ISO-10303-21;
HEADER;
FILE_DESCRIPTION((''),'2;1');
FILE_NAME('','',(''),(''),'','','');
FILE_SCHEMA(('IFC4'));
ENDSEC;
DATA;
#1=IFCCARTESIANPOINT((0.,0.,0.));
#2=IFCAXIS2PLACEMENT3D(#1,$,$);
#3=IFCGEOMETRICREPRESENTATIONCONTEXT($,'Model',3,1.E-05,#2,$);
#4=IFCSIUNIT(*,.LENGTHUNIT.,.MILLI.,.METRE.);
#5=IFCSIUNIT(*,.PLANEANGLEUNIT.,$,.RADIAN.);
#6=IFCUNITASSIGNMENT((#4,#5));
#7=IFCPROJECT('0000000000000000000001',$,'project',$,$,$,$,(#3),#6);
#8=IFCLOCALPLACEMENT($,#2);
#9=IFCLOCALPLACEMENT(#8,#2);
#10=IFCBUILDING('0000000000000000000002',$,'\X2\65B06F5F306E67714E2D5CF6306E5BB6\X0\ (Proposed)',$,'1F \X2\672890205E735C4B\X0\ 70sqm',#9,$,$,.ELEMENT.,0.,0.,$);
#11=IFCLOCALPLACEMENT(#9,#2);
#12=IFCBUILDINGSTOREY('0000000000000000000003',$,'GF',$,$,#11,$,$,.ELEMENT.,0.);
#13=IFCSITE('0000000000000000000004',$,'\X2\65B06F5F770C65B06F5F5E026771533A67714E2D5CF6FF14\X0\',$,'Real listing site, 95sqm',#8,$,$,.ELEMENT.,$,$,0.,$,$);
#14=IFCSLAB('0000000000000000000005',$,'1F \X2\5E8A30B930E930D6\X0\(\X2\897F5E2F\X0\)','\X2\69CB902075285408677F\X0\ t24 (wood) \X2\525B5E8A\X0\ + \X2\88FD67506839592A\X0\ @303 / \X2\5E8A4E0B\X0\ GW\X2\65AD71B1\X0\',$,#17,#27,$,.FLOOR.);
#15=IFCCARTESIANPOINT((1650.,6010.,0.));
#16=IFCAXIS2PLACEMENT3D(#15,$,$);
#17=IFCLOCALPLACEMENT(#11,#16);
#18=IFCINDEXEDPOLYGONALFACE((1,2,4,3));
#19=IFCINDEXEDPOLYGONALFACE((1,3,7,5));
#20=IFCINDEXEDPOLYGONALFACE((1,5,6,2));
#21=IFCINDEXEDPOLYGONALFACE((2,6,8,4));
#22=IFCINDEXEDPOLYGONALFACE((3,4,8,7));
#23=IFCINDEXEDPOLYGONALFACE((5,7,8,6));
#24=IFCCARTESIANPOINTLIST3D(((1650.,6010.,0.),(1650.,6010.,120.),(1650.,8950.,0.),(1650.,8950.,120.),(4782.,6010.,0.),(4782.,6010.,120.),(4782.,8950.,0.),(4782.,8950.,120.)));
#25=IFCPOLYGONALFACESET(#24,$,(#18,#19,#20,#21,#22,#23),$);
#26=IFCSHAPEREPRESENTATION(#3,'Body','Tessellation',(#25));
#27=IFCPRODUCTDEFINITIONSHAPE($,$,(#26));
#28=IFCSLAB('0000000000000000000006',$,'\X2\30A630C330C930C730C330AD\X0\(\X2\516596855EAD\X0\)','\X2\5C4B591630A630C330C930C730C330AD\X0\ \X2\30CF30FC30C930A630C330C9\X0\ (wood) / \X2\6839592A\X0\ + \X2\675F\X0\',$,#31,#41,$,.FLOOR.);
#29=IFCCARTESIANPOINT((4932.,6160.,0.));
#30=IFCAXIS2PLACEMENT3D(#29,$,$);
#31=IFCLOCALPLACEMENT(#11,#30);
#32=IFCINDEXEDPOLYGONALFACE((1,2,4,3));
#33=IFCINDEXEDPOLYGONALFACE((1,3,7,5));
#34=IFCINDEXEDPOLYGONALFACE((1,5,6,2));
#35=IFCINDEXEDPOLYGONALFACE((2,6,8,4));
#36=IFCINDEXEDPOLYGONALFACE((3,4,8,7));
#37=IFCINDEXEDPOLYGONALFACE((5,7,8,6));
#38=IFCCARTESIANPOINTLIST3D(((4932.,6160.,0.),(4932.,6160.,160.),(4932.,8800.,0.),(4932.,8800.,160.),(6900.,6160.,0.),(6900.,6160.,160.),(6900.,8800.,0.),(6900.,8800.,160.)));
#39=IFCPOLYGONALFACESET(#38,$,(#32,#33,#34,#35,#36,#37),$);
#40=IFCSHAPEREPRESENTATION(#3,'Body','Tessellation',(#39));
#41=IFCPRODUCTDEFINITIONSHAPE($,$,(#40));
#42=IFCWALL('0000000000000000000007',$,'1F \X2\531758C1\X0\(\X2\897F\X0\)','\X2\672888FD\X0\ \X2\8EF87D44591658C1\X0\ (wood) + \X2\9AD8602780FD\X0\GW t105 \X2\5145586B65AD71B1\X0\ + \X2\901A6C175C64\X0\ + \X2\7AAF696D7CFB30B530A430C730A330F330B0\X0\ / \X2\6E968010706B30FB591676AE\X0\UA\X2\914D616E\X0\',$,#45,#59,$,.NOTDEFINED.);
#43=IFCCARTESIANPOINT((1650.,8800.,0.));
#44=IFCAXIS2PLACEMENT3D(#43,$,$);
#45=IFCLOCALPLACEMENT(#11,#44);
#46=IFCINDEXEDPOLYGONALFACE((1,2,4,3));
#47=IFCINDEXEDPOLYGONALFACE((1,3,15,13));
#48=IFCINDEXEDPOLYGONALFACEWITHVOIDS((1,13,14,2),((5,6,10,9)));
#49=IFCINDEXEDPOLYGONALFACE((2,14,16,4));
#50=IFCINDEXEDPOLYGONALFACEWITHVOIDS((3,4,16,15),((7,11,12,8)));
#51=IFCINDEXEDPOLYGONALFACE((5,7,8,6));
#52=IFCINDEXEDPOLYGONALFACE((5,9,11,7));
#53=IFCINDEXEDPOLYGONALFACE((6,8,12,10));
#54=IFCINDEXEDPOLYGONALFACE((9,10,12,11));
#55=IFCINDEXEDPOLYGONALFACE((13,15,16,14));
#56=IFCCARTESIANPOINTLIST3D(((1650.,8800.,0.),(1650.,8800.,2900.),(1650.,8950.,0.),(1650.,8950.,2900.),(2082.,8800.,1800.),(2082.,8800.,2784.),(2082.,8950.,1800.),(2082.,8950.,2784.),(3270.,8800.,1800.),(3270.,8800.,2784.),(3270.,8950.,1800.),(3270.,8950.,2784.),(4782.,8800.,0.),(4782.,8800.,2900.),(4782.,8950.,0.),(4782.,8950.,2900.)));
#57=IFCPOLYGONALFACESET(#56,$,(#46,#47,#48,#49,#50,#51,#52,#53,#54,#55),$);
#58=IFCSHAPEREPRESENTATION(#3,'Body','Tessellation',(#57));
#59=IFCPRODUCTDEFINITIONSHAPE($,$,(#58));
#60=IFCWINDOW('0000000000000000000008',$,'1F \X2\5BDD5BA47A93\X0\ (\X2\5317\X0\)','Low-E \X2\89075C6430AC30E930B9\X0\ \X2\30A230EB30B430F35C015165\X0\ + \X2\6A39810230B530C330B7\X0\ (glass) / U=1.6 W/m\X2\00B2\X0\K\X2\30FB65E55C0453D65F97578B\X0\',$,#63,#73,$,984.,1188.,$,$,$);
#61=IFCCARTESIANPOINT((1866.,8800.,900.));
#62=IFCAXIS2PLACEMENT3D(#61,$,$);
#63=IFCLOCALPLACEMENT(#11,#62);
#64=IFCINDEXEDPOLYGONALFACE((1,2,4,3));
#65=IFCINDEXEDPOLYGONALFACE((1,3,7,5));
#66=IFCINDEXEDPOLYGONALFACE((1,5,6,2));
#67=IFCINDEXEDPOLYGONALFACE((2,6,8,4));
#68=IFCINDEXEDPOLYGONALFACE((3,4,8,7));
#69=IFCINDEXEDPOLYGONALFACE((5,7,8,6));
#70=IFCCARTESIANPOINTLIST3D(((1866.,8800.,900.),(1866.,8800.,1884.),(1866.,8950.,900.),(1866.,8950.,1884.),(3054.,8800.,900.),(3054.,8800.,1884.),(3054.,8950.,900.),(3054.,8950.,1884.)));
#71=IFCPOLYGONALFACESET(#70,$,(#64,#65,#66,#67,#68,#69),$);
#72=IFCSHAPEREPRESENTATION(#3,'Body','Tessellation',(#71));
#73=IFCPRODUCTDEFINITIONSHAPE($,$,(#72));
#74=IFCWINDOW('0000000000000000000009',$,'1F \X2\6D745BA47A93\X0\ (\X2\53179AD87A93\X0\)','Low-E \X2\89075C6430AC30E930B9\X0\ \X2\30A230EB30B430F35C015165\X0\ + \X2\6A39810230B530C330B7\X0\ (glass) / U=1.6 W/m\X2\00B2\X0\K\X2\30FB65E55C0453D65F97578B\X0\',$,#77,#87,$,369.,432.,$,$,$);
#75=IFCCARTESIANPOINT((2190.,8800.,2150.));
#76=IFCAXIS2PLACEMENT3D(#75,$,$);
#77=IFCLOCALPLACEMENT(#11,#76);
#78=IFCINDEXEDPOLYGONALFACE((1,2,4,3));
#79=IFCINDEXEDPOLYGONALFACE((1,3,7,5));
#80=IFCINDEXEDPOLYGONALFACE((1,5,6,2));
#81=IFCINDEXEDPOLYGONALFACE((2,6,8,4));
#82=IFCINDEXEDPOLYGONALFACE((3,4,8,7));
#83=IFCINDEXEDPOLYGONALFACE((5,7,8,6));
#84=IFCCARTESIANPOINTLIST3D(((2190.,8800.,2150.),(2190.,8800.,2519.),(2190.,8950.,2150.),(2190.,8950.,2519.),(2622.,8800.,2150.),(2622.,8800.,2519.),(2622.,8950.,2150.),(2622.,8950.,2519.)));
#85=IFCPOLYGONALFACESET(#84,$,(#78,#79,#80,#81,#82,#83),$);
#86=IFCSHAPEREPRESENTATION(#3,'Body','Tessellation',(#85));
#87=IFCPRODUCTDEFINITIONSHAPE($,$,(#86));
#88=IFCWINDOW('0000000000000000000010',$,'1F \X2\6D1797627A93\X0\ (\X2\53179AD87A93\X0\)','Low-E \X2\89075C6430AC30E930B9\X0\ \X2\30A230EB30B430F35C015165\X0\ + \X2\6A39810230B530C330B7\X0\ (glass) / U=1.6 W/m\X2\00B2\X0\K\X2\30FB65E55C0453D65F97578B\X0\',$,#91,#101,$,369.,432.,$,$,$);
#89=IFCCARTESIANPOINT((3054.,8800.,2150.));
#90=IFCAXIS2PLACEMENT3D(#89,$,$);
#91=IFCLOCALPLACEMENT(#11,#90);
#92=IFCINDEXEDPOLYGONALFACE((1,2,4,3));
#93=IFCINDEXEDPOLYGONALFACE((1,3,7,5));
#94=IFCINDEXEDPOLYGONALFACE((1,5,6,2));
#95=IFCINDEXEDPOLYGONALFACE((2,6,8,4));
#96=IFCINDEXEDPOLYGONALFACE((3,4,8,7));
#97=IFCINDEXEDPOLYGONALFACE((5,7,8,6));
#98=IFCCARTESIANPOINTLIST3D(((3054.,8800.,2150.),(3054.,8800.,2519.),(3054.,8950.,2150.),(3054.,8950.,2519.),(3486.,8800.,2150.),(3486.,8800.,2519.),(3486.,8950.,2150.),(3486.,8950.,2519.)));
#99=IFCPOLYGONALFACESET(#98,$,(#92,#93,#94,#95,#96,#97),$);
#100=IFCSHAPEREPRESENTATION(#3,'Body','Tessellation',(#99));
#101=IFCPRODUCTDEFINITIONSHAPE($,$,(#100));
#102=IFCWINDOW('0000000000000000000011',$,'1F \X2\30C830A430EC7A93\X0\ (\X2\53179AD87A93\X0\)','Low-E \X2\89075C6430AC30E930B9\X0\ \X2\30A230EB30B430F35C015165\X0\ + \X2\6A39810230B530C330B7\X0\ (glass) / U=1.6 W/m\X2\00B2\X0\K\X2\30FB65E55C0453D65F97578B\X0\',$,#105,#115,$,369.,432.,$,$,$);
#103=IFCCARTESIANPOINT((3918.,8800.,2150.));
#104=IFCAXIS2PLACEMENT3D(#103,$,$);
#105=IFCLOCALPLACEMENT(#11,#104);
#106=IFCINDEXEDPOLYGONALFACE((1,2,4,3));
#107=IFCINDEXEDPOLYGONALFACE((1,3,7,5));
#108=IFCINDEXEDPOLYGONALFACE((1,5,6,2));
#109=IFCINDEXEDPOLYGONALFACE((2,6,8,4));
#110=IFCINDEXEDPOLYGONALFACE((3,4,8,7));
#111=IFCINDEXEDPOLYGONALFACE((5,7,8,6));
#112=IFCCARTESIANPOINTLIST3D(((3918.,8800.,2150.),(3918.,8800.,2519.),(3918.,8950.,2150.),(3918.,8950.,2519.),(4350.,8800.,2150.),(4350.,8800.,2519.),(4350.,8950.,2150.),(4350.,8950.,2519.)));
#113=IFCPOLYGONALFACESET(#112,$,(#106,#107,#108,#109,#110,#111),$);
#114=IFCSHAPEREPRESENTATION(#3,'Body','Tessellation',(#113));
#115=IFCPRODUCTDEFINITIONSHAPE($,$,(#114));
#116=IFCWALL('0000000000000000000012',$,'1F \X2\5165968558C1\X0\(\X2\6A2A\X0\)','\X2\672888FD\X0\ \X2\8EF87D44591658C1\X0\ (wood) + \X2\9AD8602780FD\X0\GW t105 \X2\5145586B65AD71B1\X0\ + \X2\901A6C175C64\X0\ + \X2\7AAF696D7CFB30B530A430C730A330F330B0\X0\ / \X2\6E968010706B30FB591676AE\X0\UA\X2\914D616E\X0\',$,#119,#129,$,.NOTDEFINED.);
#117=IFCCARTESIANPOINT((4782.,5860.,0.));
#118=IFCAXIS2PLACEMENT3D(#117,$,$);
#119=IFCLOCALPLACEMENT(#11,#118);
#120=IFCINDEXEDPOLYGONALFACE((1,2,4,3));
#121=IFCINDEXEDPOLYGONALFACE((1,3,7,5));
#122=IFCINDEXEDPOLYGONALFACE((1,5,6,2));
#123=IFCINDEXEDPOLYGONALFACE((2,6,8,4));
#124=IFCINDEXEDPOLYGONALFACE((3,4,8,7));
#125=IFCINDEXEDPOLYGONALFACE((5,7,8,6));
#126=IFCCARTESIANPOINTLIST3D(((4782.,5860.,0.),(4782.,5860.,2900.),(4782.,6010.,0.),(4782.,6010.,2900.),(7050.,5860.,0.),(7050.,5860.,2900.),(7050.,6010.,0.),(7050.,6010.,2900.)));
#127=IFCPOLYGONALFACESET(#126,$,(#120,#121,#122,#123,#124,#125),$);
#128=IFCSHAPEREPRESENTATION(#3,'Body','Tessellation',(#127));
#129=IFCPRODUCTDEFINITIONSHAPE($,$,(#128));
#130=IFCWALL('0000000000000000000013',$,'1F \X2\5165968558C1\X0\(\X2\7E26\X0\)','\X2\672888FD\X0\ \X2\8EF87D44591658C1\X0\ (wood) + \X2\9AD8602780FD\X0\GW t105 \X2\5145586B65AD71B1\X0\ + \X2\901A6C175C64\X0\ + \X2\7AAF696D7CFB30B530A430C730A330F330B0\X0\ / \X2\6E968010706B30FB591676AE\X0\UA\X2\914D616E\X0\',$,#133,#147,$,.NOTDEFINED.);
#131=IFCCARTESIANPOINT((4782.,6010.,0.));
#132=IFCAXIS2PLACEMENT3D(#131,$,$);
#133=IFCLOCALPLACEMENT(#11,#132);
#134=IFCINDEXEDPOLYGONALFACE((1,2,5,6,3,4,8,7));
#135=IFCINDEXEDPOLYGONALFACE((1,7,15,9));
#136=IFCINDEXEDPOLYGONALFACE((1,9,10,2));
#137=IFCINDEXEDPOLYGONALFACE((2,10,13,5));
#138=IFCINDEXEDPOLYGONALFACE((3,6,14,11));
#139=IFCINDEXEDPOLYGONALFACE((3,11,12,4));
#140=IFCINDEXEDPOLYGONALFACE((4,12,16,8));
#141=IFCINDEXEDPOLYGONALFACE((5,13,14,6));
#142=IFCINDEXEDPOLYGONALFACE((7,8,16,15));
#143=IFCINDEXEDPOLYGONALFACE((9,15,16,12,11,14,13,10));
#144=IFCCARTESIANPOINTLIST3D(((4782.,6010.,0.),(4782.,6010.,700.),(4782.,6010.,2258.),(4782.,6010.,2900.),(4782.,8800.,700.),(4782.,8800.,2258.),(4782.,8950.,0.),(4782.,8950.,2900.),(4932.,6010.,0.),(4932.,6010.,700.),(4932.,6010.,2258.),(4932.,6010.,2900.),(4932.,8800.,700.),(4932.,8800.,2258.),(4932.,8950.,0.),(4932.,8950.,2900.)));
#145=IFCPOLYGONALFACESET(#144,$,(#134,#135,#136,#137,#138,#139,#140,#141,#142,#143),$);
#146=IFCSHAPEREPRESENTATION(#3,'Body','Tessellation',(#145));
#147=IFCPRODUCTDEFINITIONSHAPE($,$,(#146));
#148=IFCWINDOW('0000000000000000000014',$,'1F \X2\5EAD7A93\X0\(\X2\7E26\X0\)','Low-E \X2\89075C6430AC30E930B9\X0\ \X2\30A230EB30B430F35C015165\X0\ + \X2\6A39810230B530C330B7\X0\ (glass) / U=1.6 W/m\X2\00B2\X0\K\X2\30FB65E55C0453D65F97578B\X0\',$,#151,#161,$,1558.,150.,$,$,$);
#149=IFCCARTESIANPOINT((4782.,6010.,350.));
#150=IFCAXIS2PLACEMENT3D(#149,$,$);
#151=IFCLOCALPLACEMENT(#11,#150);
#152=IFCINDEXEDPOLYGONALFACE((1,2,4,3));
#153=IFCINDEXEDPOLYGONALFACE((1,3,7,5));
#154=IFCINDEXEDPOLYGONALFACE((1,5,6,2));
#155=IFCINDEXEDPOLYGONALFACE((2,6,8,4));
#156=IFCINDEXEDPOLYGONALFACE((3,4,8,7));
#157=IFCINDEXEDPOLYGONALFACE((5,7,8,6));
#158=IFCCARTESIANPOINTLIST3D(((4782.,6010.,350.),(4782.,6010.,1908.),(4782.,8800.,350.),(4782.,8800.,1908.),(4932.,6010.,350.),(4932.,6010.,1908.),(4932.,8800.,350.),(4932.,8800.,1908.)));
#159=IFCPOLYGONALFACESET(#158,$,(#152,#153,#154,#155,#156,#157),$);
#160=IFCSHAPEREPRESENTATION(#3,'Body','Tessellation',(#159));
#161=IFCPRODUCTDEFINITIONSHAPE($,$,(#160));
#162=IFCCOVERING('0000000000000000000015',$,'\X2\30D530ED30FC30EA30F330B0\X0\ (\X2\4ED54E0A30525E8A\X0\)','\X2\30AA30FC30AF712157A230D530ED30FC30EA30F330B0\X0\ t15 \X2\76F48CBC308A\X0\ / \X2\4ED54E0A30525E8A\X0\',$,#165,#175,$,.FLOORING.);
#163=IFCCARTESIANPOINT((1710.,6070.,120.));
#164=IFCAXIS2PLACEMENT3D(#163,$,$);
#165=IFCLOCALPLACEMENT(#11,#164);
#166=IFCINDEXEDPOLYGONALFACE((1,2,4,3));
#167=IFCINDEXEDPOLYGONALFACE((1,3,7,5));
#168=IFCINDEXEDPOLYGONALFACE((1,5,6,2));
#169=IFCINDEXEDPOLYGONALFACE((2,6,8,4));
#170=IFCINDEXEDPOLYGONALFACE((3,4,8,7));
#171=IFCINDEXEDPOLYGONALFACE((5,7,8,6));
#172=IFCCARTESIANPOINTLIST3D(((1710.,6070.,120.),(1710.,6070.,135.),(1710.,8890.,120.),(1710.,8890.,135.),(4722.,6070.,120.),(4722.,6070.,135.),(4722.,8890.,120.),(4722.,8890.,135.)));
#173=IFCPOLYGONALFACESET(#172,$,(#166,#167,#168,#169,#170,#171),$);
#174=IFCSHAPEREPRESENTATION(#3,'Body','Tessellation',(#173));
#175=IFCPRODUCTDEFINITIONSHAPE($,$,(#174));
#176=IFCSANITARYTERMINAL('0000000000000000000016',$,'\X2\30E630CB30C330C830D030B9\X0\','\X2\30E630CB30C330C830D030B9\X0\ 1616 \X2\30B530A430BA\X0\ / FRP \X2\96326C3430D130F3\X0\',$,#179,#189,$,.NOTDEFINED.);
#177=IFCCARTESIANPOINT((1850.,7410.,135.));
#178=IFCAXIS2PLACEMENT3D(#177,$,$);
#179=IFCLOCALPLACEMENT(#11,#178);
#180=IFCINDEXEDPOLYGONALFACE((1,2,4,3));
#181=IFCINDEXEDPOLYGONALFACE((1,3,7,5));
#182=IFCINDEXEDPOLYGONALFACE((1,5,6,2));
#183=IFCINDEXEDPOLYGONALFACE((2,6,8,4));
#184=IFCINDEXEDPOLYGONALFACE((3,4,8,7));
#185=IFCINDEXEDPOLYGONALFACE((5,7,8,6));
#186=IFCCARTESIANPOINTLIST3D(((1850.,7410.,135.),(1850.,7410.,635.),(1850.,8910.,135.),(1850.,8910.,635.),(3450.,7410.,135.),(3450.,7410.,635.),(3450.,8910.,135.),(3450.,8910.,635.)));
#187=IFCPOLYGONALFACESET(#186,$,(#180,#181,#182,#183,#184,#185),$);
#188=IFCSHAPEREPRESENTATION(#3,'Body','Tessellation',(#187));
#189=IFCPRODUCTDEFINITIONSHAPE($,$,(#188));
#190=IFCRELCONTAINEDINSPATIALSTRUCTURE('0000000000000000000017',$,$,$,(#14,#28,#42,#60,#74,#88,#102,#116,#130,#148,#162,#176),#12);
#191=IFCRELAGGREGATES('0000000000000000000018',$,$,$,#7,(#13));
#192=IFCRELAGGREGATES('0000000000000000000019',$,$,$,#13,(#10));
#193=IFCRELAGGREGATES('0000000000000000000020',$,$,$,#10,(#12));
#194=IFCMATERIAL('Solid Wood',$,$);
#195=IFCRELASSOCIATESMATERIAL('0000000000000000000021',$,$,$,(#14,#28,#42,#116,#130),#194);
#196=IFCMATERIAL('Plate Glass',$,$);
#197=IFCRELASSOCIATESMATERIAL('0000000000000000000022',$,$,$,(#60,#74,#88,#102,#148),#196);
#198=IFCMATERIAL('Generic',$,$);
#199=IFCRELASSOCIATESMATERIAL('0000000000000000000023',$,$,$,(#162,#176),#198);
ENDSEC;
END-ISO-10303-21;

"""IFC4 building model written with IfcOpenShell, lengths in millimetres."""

from ifc_helpers import new_model, si_unit, frame, frame_2d, origin, place, context, project, spatial, rectangle, extrude, material, element, fill, save


model = new_model("IFC4")

# Units and contexts
model_context = context("Model", 3, precision=1e-05, world=origin())
ifc_project = project(units=[si_unit("LENGTHUNIT", "METRE", prefix="MILLI"), si_unit("PLANEANGLEUNIT", "RADIAN")], contexts=[model_context])

# Site, building, storey
site_placement = place(None, origin())
site = spatial("IfcSite", under=ifc_project, at=site_placement, Name="新潟県新潟市東区東中島４", ObjectType="Real listing site, 95sqm", CompositionType="ELEMENT", RefElevation=0.0)
building_placement = place(site_placement, origin())
building = spatial("IfcBuilding", under=site, at=building_placement, Name="新潟の東中島の家 (Proposed)", ObjectType="1F 木造平屋 70sqm", CompositionType="ELEMENT", ElevationOfRefHeight=0.0, ElevationOfTerrain=0.0)
storey_placement = place(building_placement, origin())
storey = spatial("IfcBuildingStorey", under=building, at=storey_placement, Name="GF", CompositionType="ELEMENT", Elevation=0.0)

# Slabs
ifc_material_1 = material(Name="Solid Wood")
slab_1_placement = place(storey_placement, frame((1650.0, 6010.0, 0.0)))
element("IfcSlab", 1, at=slab_1_placement, inside=storey, material=ifc_material_1, Name="1F 床スラブ(西帯)", Description="構造用合板 t24 (wood) 剛床 + 製材根太 @303 / 床下 GW断熱", PredefinedType="FLOOR", context=model_context, shape_type="SweptSolid", body=[
    extrude(rectangle(XDim=3132.0, YDim=2940.0, at=frame_2d((1566.0, 1470.0))), frame((1650.0, 6010.0, 0.0)), (0.0, 0.0, 1.0), 120.0),
])
slab_2_placement = place(storey_placement, frame((4932.0, 6160.0, 0.0)))
element("IfcSlab", 2, at=slab_2_placement, inside=storey, material=ifc_material_1, Name="ウッドデッキ(入隅庭)", Description="屋外ウッドデッキ ハードウッド (wood) / 根太 + 束", PredefinedType="FLOOR", context=model_context, shape_type="SweptSolid", body=[
    extrude(rectangle(XDim=1968.0, YDim=2640.0, at=frame_2d((984.0, 1320.0))), frame((4932.0, 6160.0, 0.0)), (0.0, 0.0, 1.0), 160.0),
])

# Wall, openings, windows
wall_1_placement = place(storey_placement, frame((1650.0, 8800.0, 0.0)))
wall_1 = element("IfcWall", 3, at=wall_1_placement, inside=storey, material=ifc_material_1, Name="1F 北壁(西)", Description="木製 軸組外壁 (wood) + 高性能GW t105 充填断熱 + 通気層 + 窯業系サイディング / 準耐火・外皮UA配慮", PredefinedType="NOTDEFINED", context=model_context, shape_type="SweptSolid", body=[
    extrude(rectangle(XDim=3132.0, YDim=150.0, at=frame_2d((1566.0, 75.0))), frame((1650.0, 8800.0, 0.0)), (0.0, 0.0, 1.0), 2900.0),
])
opening_1_placement = place(storey_placement, frame((1866.0, 8800.0, 900.0)))
opening_1 = element("IfcOpeningElement", 4, at=opening_1_placement, cuts=wall_1, PredefinedType="NOTDEFINED", context=model_context, shape_type="SweptSolid", body=[
    extrude(rectangle(XDim=1188.0, YDim=150.0, at=frame_2d((594.0, 75.0))), frame((1866.0, 8800.0, 900.0)), (0.0, 0.0, 1.0), 984.0),
])
opening_2_placement = place(storey_placement, frame((2190.0, 8800.0, 2150.0)))
opening_2 = element("IfcOpeningElement", 5, at=opening_2_placement, cuts=wall_1, PredefinedType="NOTDEFINED", context=model_context, shape_type="SweptSolid", body=[
    extrude(rectangle(XDim=432.0, YDim=150.0, at=frame_2d((216.0, 75.0))), frame((2190.0, 8800.0, 2150.0)), (0.0, 0.0, 1.0), 369.0),
])
opening_3_placement = place(storey_placement, frame((3054.0, 8800.0, 2150.0)))
opening_3 = element("IfcOpeningElement", 6, at=opening_3_placement, cuts=wall_1, PredefinedType="NOTDEFINED", context=model_context, shape_type="SweptSolid", body=[
    extrude(rectangle(XDim=432.0, YDim=150.0, at=frame_2d((216.0, 75.0))), frame((3054.0, 8800.0, 2150.0)), (0.0, 0.0, 1.0), 369.0),
])
opening_4_placement = place(storey_placement, frame((3918.0, 8800.0, 2150.0)))
opening_4 = element("IfcOpeningElement", 7, at=opening_4_placement, cuts=wall_1, PredefinedType="NOTDEFINED", context=model_context, shape_type="SweptSolid", body=[
    extrude(rectangle(XDim=432.0, YDim=150.0, at=frame_2d((216.0, 75.0))), frame((3918.0, 8800.0, 2150.0)), (0.0, 0.0, 1.0), 369.0),
])
ifc_material_2 = material(Name="Plate Glass")
window_1_placement = place(storey_placement, frame((1866.0, 8800.0, 900.0)))
window_1 = element("IfcWindow", 8, at=window_1_placement, inside=storey, material=ifc_material_2, Name="1F 寝室窓 (北)", Description="Low-E 複層ガラス アルゴン封入 + 樹脂サッシ (glass) / U=1.6 W/m²K・日射取得型", OverallHeight=984.0, OverallWidth=1188.0, context=model_context, shape_type="SweptSolid", body=[
    extrude(rectangle(XDim=1188.0, YDim=150.0, at=frame_2d((594.0, 75.0))), frame((1866.0, 8800.0, 900.0)), (0.0, 0.0, 1.0), 984.0),
])
fill(opening_1, window_1)
window_2_placement = place(storey_placement, frame((2190.0, 8800.0, 2150.0)))
window_2 = element("IfcWindow", 9, at=window_2_placement, inside=storey, material=ifc_material_2, Name="1F 浴室窓 (北高窓)", Description="Low-E 複層ガラス アルゴン封入 + 樹脂サッシ (glass) / U=1.6 W/m²K・日射取得型", OverallHeight=369.0, OverallWidth=432.0, context=model_context, shape_type="SweptSolid", body=[
    extrude(rectangle(XDim=432.0, YDim=150.0, at=frame_2d((216.0, 75.0))), frame((2190.0, 8800.0, 2150.0)), (0.0, 0.0, 1.0), 369.0),
])
fill(opening_2, window_2)
window_3_placement = place(storey_placement, frame((3054.0, 8800.0, 2150.0)))
window_3 = element("IfcWindow", 10, at=window_3_placement, inside=storey, material=ifc_material_2, Name="1F 洗面窓 (北高窓)", Description="Low-E 複層ガラス アルゴン封入 + 樹脂サッシ (glass) / U=1.6 W/m²K・日射取得型", OverallHeight=369.0, OverallWidth=432.0, context=model_context, shape_type="SweptSolid", body=[
    extrude(rectangle(XDim=432.0, YDim=150.0, at=frame_2d((216.0, 75.0))), frame((3054.0, 8800.0, 2150.0)), (0.0, 0.0, 1.0), 369.0),
])
fill(opening_3, window_3)
window_4_placement = place(storey_placement, frame((3918.0, 8800.0, 2150.0)))
window_4 = element("IfcWindow", 11, at=window_4_placement, inside=storey, material=ifc_material_2, Name="1F トイレ窓 (北高窓)", Description="Low-E 複層ガラス アルゴン封入 + 樹脂サッシ (glass) / U=1.6 W/m²K・日射取得型", OverallHeight=369.0, OverallWidth=432.0, context=model_context, shape_type="SweptSolid", body=[
    extrude(rectangle(XDim=432.0, YDim=150.0, at=frame_2d((216.0, 75.0))), frame((3918.0, 8800.0, 2150.0)), (0.0, 0.0, 1.0), 369.0),
])
fill(opening_4, window_4)

# Wall
wall_2_placement = place(storey_placement, frame((4782.0, 5860.0, 0.0)))
element("IfcWall", 12, at=wall_2_placement, inside=storey, material=ifc_material_1, Name="1F 入隅壁(横)", Description="木製 軸組外壁 (wood) + 高性能GW t105 充填断熱 + 通気層 + 窯業系サイディング / 準耐火・外皮UA配慮", PredefinedType="NOTDEFINED", context=model_context, shape_type="SweptSolid", body=[
    extrude(rectangle(XDim=2268.0, YDim=150.0, at=frame_2d((1134.0, 75.0))), frame((4782.0, 5860.0, 0.0)), (0.0, 0.0, 1.0), 2900.0),
])

# Wall, opening, window
wall_3_placement = place(storey_placement, frame((4782.0, 6010.0, 0.0)))
wall_3 = element("IfcWall", 13, at=wall_3_placement, inside=storey, material=ifc_material_1, Name="1F 入隅壁(縦)", Description="木製 軸組外壁 (wood) + 高性能GW t105 充填断熱 + 通気層 + 窯業系サイディング / 準耐火・外皮UA配慮", PredefinedType="NOTDEFINED", context=model_context, shape_type="SweptSolid", body=[
    extrude(rectangle(XDim=150.0, YDim=2940.0, at=frame_2d((75.0, 1470.0))), frame((4782.0, 6010.0, 0.0)), (0.0, 0.0, 1.0), 2900.0),
])
opening_5_placement = place(storey_placement, frame((4782.0, 6010.0, 350.0)))
opening_5 = element("IfcOpeningElement", 14, at=opening_5_placement, cuts=wall_3, PredefinedType="NOTDEFINED", context=model_context, shape_type="SweptSolid", body=[
    extrude(rectangle(XDim=150.0, YDim=2790.0, at=frame_2d((75.0, 1395.0))), frame((4782.0, 6010.0, 350.0)), (0.0, 0.0, 1.0), 1558.0),
])
window_5_placement = place(storey_placement, frame((4782.0, 6010.0, 350.0)))
window_5 = element("IfcWindow", 15, at=window_5_placement, inside=storey, material=ifc_material_2, Name="1F 庭窓(縦)", Description="Low-E 複層ガラス アルゴン封入 + 樹脂サッシ (glass) / U=1.6 W/m²K・日射取得型", OverallHeight=1558.0, OverallWidth=150.0, context=model_context, shape_type="SweptSolid", body=[
    extrude(rectangle(XDim=150.0, YDim=2790.0, at=frame_2d((75.0, 1395.0))), frame((4782.0, 6010.0, 350.0)), (0.0, 0.0, 1.0), 1558.0),
])
fill(opening_5, window_5)

# Covering
ifc_material_3 = material(Name="Generic")
covering_placement = place(storey_placement, frame((1710.0, 6070.0, 120.0)))
element("IfcCovering", 16, at=covering_placement, inside=storey, material=ifc_material_3, Name="フローリング (仕上げ床)", Description="オーク無垢フローリング t15 直貼り / 仕上げ床", PredefinedType="FLOORING", context=model_context, shape_type="SweptSolid", body=[
    extrude(rectangle(XDim=3012.0, YDim=2820.0, at=frame_2d((1506.0, 1410.0))), frame((1710.0, 6070.0, 120.0)), (0.0, 0.0, 1.0), 15.0),
])

# Sanitary terminal
sanitary_terminal_1_placement = place(storey_placement, frame((1850.0, 7410.0, 135.0)))
element("IfcSanitaryTerminal", 17, at=sanitary_terminal_1_placement, inside=storey, material=ifc_material_3, Name="ユニットバス", Description="ユニットバス 1616 サイズ / FRP 防水パン", PredefinedType="NOTDEFINED", context=model_context, shape_type="SweptSolid", body=[
    extrude(rectangle(XDim=1600.0, YDim=1500.0, at=frame_2d((800.0, 750.0))), frame((1850.0, 7410.0, 135.0)), (0.0, 0.0, 1.0), 500.0),
])

save(model, "model.ifc")
